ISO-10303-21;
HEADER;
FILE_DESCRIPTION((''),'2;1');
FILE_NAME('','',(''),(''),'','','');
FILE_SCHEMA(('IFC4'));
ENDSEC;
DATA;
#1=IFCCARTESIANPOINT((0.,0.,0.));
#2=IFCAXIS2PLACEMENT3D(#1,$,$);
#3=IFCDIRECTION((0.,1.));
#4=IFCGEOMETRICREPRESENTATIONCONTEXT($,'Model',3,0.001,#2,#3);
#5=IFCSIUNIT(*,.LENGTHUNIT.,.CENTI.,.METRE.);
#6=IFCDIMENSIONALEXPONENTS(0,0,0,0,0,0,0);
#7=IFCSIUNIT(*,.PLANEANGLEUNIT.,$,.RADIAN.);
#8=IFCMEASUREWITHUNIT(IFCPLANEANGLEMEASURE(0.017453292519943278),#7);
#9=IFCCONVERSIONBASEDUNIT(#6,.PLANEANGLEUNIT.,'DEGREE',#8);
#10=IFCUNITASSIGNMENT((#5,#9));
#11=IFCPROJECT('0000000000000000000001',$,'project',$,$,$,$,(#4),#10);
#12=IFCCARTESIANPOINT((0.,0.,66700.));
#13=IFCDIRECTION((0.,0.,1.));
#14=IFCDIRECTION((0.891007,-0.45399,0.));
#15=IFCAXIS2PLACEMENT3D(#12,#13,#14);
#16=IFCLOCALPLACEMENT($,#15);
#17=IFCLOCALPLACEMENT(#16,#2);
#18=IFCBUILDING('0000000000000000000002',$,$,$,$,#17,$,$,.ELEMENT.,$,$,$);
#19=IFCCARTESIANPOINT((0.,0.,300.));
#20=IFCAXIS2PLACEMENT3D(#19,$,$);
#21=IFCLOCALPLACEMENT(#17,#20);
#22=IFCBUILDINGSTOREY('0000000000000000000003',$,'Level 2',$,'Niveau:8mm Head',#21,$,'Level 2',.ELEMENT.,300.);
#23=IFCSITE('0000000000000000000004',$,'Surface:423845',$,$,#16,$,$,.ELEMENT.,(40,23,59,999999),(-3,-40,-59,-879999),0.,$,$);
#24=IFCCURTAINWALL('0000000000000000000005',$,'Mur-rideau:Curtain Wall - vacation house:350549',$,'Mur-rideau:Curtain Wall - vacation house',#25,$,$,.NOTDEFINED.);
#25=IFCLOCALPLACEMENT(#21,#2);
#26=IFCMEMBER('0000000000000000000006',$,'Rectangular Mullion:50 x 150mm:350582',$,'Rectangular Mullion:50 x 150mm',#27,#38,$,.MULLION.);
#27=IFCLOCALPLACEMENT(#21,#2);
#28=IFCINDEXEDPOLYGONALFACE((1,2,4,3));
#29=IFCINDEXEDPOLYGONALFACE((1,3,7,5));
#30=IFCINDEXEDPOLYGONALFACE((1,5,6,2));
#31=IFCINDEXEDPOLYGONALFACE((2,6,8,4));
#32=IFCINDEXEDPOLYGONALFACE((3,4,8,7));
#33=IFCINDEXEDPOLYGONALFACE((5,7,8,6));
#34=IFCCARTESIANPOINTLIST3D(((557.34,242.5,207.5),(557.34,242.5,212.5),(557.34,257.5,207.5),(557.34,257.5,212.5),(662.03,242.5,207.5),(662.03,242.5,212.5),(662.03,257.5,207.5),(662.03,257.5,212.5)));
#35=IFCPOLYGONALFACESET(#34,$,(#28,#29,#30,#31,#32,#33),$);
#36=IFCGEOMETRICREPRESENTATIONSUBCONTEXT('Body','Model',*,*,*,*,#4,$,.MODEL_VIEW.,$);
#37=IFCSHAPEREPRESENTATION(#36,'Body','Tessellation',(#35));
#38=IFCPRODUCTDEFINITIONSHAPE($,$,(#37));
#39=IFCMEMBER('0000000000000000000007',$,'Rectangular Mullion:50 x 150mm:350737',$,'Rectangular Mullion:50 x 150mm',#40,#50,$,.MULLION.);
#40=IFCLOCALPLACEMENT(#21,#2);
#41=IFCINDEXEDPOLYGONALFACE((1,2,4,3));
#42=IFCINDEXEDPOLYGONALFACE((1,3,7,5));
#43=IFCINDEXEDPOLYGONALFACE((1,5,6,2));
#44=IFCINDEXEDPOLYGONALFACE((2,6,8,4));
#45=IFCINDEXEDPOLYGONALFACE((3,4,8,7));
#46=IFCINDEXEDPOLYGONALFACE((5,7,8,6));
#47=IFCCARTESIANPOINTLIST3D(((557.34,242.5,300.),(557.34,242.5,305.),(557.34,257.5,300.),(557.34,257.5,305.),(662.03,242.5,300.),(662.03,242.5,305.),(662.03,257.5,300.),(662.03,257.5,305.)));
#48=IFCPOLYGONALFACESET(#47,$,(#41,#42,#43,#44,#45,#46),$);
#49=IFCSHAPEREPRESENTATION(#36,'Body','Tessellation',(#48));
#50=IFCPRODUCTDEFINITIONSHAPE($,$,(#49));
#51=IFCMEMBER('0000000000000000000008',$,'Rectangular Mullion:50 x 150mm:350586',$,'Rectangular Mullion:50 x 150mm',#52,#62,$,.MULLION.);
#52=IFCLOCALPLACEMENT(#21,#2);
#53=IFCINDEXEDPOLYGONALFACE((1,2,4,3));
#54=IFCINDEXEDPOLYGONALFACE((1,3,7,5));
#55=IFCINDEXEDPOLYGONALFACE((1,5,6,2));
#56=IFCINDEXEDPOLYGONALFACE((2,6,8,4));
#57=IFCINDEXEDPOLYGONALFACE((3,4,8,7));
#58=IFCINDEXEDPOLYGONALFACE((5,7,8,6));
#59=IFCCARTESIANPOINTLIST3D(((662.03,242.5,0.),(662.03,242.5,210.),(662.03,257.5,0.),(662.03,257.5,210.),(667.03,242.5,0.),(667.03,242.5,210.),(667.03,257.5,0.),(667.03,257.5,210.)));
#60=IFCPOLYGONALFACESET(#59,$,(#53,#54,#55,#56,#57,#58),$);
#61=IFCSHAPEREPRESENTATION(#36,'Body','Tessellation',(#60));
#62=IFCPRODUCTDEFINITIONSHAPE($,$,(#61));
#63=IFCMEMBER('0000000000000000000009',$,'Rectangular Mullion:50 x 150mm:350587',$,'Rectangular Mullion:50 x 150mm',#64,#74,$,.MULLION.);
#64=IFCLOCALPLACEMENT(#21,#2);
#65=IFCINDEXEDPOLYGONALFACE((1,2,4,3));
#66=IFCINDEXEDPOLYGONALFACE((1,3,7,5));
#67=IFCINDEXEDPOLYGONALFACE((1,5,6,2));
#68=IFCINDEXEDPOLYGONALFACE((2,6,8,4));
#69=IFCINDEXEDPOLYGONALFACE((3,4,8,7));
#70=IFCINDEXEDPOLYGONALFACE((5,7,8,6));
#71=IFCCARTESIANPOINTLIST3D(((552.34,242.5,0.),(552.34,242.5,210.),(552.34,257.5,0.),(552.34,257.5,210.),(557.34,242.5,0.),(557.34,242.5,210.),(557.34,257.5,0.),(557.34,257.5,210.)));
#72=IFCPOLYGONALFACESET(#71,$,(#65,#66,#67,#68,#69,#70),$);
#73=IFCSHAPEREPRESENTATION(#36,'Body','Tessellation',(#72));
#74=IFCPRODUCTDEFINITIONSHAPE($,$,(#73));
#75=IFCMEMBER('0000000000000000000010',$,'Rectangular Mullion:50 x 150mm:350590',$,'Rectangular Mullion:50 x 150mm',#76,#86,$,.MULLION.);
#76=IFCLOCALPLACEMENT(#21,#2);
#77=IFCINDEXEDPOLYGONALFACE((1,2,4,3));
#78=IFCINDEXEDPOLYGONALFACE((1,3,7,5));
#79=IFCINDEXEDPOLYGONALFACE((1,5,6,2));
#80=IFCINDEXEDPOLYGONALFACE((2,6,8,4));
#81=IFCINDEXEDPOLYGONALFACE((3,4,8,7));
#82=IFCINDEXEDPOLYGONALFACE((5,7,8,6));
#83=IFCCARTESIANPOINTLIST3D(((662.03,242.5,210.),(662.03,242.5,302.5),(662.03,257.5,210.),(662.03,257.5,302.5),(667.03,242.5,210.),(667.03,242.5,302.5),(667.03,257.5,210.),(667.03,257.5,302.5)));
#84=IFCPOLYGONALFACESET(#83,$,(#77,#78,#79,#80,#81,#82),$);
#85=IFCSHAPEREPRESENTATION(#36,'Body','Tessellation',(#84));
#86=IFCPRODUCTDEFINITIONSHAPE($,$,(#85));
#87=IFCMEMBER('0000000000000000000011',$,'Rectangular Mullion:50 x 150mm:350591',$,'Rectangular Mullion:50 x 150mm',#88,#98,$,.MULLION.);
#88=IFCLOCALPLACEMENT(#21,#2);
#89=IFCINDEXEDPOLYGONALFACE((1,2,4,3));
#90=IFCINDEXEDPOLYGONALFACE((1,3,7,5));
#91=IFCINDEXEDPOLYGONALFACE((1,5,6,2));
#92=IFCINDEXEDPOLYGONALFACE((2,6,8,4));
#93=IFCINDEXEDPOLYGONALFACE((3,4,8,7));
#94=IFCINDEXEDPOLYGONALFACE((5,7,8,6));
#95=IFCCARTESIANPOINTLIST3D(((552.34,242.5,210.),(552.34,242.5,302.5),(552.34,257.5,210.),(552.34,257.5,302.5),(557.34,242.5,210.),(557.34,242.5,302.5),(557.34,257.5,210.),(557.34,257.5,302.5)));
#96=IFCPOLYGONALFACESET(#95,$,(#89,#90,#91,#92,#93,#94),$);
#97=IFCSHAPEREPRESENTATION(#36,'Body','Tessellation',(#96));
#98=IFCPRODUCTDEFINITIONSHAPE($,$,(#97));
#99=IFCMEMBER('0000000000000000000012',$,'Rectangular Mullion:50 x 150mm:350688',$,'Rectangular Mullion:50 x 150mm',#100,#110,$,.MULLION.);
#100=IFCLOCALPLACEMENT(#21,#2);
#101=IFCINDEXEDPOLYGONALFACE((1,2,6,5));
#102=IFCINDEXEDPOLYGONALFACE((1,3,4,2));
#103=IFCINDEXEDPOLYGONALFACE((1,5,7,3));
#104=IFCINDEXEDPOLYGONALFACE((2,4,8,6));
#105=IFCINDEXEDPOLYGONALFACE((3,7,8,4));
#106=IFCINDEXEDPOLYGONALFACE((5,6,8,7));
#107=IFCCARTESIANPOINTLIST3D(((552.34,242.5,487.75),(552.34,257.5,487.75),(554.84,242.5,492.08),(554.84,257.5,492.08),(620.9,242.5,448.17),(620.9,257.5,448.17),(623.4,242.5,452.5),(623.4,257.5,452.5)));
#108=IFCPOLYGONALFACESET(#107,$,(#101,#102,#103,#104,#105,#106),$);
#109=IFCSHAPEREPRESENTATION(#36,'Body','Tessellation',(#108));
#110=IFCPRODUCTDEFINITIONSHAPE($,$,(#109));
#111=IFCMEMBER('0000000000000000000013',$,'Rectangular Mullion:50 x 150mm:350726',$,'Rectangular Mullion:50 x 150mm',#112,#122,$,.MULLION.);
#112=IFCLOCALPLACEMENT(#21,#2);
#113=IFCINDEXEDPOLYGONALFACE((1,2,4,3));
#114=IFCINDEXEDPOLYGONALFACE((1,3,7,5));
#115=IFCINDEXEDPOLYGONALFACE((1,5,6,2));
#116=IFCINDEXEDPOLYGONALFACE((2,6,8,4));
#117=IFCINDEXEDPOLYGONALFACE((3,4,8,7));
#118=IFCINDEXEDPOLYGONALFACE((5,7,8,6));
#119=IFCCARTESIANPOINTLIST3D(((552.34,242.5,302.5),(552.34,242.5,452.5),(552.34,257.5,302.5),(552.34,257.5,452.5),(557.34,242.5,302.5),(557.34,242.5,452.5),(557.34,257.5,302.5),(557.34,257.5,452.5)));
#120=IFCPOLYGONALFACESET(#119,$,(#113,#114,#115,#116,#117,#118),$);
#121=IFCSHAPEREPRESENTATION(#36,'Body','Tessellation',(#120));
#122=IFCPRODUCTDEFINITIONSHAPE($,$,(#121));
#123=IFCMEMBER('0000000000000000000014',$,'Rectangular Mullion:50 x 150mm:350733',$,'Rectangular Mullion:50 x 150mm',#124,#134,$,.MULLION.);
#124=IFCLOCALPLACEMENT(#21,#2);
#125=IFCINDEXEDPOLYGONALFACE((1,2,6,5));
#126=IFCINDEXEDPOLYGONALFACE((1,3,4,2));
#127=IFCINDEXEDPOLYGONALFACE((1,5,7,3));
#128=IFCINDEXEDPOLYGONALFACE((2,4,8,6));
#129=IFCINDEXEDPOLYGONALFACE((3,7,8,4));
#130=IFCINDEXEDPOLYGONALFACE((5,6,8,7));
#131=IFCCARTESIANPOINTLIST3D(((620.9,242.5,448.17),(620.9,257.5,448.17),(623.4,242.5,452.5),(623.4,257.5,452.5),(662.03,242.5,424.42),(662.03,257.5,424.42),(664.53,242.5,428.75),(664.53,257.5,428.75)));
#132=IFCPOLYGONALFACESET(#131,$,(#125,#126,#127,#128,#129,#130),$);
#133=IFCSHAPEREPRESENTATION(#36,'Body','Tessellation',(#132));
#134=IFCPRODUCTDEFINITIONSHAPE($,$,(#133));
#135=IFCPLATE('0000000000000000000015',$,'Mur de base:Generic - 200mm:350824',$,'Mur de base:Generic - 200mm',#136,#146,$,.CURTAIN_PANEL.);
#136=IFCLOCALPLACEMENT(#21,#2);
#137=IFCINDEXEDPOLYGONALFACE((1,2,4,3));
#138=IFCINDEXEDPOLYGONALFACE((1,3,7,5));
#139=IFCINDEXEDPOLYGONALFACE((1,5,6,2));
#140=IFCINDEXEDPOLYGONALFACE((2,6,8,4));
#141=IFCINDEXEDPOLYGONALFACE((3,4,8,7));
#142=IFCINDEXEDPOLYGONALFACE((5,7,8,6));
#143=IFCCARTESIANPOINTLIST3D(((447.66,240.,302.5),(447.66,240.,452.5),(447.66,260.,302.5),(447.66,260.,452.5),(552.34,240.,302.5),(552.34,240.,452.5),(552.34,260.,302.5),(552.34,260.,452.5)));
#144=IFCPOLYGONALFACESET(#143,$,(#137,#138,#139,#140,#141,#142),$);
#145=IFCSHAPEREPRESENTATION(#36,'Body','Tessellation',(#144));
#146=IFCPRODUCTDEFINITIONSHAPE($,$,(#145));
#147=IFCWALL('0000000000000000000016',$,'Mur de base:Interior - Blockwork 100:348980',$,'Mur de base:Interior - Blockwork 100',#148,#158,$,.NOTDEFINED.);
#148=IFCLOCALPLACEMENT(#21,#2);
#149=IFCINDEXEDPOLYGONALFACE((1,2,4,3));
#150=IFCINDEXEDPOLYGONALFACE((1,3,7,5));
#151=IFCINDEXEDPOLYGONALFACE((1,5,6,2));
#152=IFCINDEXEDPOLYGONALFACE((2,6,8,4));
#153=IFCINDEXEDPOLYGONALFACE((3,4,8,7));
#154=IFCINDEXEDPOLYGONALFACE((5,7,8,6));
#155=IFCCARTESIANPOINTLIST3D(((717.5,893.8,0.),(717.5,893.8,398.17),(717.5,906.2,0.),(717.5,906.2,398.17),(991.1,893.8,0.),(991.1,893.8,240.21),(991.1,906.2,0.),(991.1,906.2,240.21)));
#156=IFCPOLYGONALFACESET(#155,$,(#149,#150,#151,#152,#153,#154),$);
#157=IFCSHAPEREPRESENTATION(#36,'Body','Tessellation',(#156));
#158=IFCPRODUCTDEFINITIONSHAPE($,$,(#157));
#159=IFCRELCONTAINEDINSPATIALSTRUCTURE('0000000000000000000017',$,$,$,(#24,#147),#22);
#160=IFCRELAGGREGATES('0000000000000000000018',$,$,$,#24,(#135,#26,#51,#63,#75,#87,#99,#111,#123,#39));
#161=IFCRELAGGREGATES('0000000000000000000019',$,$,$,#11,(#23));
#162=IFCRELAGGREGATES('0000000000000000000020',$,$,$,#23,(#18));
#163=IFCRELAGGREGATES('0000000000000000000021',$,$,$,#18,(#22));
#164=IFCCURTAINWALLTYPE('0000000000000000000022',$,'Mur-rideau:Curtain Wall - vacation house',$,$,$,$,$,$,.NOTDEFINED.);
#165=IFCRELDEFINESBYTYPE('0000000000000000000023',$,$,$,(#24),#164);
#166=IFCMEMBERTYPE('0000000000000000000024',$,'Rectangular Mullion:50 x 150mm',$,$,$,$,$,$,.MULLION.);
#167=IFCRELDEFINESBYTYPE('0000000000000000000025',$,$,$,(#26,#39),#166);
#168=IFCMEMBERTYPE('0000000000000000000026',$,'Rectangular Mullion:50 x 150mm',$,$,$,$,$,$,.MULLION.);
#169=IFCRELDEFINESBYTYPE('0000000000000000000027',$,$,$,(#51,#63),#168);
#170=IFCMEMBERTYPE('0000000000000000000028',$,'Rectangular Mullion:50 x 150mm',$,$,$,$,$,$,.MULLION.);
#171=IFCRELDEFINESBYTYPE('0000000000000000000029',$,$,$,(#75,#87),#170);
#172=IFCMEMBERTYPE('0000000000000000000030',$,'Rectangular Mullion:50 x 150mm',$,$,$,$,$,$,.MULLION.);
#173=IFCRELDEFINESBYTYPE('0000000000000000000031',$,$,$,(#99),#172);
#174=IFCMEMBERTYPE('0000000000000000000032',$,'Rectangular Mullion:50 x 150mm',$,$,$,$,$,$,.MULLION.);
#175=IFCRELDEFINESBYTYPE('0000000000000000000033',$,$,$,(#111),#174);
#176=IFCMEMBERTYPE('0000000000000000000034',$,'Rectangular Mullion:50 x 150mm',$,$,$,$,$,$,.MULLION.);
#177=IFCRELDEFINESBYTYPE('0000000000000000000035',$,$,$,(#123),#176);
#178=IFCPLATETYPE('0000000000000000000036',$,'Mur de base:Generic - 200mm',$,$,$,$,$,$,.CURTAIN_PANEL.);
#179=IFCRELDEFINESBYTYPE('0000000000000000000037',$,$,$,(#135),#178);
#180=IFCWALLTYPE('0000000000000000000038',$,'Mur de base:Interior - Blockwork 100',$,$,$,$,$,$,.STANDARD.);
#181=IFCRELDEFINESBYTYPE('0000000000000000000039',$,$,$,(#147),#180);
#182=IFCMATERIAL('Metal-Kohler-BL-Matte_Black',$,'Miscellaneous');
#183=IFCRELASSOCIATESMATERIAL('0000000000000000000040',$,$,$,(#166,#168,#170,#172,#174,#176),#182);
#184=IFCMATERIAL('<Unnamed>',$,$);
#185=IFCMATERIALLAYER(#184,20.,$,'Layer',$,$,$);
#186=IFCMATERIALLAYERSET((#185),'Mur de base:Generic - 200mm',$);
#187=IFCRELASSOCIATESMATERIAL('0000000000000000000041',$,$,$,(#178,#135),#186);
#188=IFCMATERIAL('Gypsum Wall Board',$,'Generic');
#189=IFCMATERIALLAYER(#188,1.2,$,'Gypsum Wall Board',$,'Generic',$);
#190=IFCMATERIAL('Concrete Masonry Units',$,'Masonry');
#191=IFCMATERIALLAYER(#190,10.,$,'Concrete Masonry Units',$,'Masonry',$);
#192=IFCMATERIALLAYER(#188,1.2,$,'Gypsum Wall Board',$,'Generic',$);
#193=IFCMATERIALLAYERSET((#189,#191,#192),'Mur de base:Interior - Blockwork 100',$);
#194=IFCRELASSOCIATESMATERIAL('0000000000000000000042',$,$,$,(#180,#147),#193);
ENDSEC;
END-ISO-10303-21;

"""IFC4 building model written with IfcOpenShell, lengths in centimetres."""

from ifc_helpers import new_model, entity, si_unit, converted_unit, direction, frame, frame_2d, origin, origin_2d_with_axis, place, context, subcontext, project, spatial, polyline, rectangle, extrude, clip, bounded_halfspace, source, transform, mapped, material, layer, layer_set, layer_usage, material_profile, profile_set, type_object, type_shapes, element, aggregate, save


model = new_model("IFC4")

# Units and contexts
model_context = context("Model", 3, precision=0.001, world=origin(), true_north=direction((0.0, 1.0)))
body_context = subcontext(model_context, "Body", "Model", "MODEL_VIEW")
ifc_project = project(units=[si_unit("LENGTHUNIT", "METRE", prefix="CENTI"), converted_unit("PLANEANGLEUNIT", "DEGREE", entity("IfcPlaneAngleMeasure", 0.017453292519943278), si_unit("PLANEANGLEUNIT", "RADIAN"), dimensions=[0, 0, 0, 0, 0, 0, 0])], contexts=[model_context])

# Site, building, storey
site_placement = place(None, frame((0.0, 0.0, 66700.0), z_axis=(0.0, 0.0, 1.0), x_axis=(0.891007, -0.45399, 0.0)))
site = spatial("IfcSite", under=ifc_project, at=site_placement, Name="Surface:423845", CompositionType="ELEMENT", RefLatitude=(40, 23, 59, 999999), RefLongitude=(-3, -40, -59, -879999), RefElevation=0.0)
building_placement = place(site_placement, origin())
building = spatial("IfcBuilding", under=site, at=building_placement, CompositionType="ELEMENT")
storey_placement = place(building_placement, frame((0.0, 0.0, 300.0)))
storey = spatial("IfcBuildingStorey", under=building, at=storey_placement, Name="Level 2", ObjectType="Niveau:8mm Head", LongName="Level 2", CompositionType="ELEMENT", Elevation=300.0)

# Curtain wall, members, plate
curtain_wall_type = type_object("IfcCurtainWallType", Name="Mur-rideau:Curtain Wall - vacation house", PredefinedType="NOTDEFINED")
curtain_wall_placement = place(storey_placement, frame((0.0, 0.0, -300.0)))
curtain_wall = element("IfcCurtainWall", 1, at=curtain_wall_placement, inside=storey, type_object=curtain_wall_type, Name="Mur-rideau:Curtain Wall - vacation house:350549", ObjectType="Mur-rideau:Curtain Wall - vacation house", PredefinedType="NOTDEFINED")
ifc_material_1 = material(Name="Metal-Kohler-BL-Matte_Black", Category="Miscellaneous")
ifc_material_profile = material_profile(ifc_material_1, rectangle(XDim=5.0, YDim=15.0, at=origin_2d_with_axis()), Name="50 x 150mm")
ifc_profile_set = profile_set([ifc_material_profile], Name="50 x 150mm")
member_type_1 = type_object("IfcMemberType", Name="Rectangular Mullion:50 x 150mm", PredefinedType="MULLION", material=ifc_profile_set)
shared_shape_1 = source(origin(), body_context, "Body", "SweptSolid", [
    extrude(rectangle(XDim=5.0, YDim=15.0, at=origin_2d_with_axis()), frame((0.0, 0.0, -104.69), z_axis=(0.0, 0.0, 1.0), x_axis=(-1.0, 0.0, 0.0)), (0.0, 0.0, 1.0), 104.69),
])
type_shapes(member_type_1, [shared_shape_1])
member_1_placement = place(curtain_wall_placement, frame((557.34, 250.0, 510.0), z_axis=(-1.0, 0.0, 0.0), x_axis=(0.0, 0.0, 1.0)))
member_1 = element("IfcMember", 2, at=member_1_placement, type_object=member_type_1, Name="Rectangular Mullion:50 x 150mm:350582", ObjectType="Rectangular Mullion:50 x 150mm", PredefinedType="MULLION", context=body_context, shape_type="MappedRepresentation", body=[
    mapped(shared_shape_1, transform((0.0, 0.0, 0.0), scale=1.0)),
])
member_2_placement = place(curtain_wall_placement, frame((557.34, 250.0, 602.5), z_axis=(-1.0, 0.0, 0.0), x_axis=(0.0, 0.0, 1.0)))
member_2 = element("IfcMember", 3, at=member_2_placement, type_object=member_type_1, Name="Rectangular Mullion:50 x 150mm:350737", ObjectType="Rectangular Mullion:50 x 150mm", PredefinedType="MULLION", context=body_context, shape_type="MappedRepresentation", body=[
    mapped(shared_shape_1, transform((0.0, 0.0, 0.0), scale=1.0)),
])
member_type_2 = type_object("IfcMemberType", Name="Rectangular Mullion:50 x 150mm", PredefinedType="MULLION", material=ifc_profile_set)
shared_shape_2 = source(origin(), body_context, "Body", "SweptSolid", [
    extrude(rectangle(XDim=5.0, YDim=15.0, at=origin_2d_with_axis()), frame((0.0, 0.0, -210.0), z_axis=(0.0, 0.0, 1.0), x_axis=(-1.0, 0.0, 0.0)), (0.0, 0.0, 1.0), 210.0),
])
type_shapes(member_type_2, [shared_shape_2])
member_3_placement = place(curtain_wall_placement, frame((664.53, 250.0, 300.0), z_axis=(0.0, 0.0, -1.0), x_axis=(-1.0, 0.0, 0.0)))
member_3 = element("IfcMember", 4, at=member_3_placement, type_object=member_type_2, Name="Rectangular Mullion:50 x 150mm:350586", ObjectType="Rectangular Mullion:50 x 150mm", PredefinedType="MULLION", context=body_context, shape_type="MappedRepresentation", body=[
    mapped(shared_shape_2, transform((0.0, 0.0, 0.0), scale=1.0)),
])
member_4_placement = place(curtain_wall_placement, frame((554.84, 250.0, 300.0), z_axis=(0.0, 0.0, -1.0), x_axis=(-1.0, 0.0, 0.0)))
member_4 = element("IfcMember", 5, at=member_4_placement, type_object=member_type_2, Name="Rectangular Mullion:50 x 150mm:350587", ObjectType="Rectangular Mullion:50 x 150mm", PredefinedType="MULLION", context=body_context, shape_type="MappedRepresentation", body=[
    mapped(shared_shape_2, transform((0.0, 0.0, 0.0), scale=1.0)),
])
member_type_3 = type_object("IfcMemberType", Name="Rectangular Mullion:50 x 150mm", PredefinedType="MULLION", material=ifc_profile_set)
shared_shape_3 = source(origin(), body_context, "Body", "SweptSolid", [
    extrude(rectangle(XDim=5.0, YDim=15.0, at=origin_2d_with_axis()), frame((0.0, 0.0, -92.5), z_axis=(0.0, 0.0, 1.0), x_axis=(-1.0, 0.0, 0.0)), (0.0, 0.0, 1.0), 92.5),
])
type_shapes(member_type_3, [shared_shape_3])
member_5_placement = place(curtain_wall_placement, frame((664.53, 250.0, 510.0), z_axis=(0.0, 0.0, -1.0), x_axis=(-1.0, 0.0, 0.0)))
member_5 = element("IfcMember", 6, at=member_5_placement, type_object=member_type_3, Name="Rectangular Mullion:50 x 150mm:350590", ObjectType="Rectangular Mullion:50 x 150mm", PredefinedType="MULLION", context=body_context, shape_type="MappedRepresentation", body=[
    mapped(shared_shape_3, transform((0.0, 0.0, 0.0), scale=1.0)),
])
member_6_placement = place(curtain_wall_placement, frame((554.84, 250.0, 510.0), z_axis=(0.0, 0.0, -1.0), x_axis=(-1.0, 0.0, 0.0)))
member_6 = element("IfcMember", 7, at=member_6_placement, type_object=member_type_3, Name="Rectangular Mullion:50 x 150mm:350591", ObjectType="Rectangular Mullion:50 x 150mm", PredefinedType="MULLION", context=body_context, shape_type="MappedRepresentation", body=[
    mapped(shared_shape_3, transform((0.0, 0.0, 0.0), scale=1.0)),
])
member_type_4 = type_object("IfcMemberType", Name="Rectangular Mullion:50 x 150mm", PredefinedType="MULLION", material=ifc_profile_set)
shared_shape_4 = source(origin(), body_context, "Body", "SweptSolid", [
    extrude(rectangle(XDim=5.0, YDim=15.0, at=origin_2d_with_axis()), frame((-2.5, 0.0, -79.16), z_axis=(0.0, 0.0, 1.0), x_axis=(-1.0, 0.0, 0.0)), (0.0, 0.0, 1.0), 79.16),
])
type_shapes(member_type_4, [shared_shape_4])
member_7_placement = place(curtain_wall_placement, frame((554.84, 250.0, 792.08), z_axis=(-0.866025, 0.0, 0.5), x_axis=(0.5, 0.0, 0.866025)))
member_7 = element("IfcMember", 8, at=member_7_placement, type_object=member_type_4, Name="Rectangular Mullion:50 x 150mm:350688", ObjectType="Rectangular Mullion:50 x 150mm", PredefinedType="MULLION", context=body_context, shape_type="MappedRepresentation", body=[
    mapped(shared_shape_4, transform((0.0, 0.0, 0.0), scale=1.0)),
])
member_type_5 = type_object("IfcMemberType", Name="Rectangular Mullion:50 x 150mm", PredefinedType="MULLION", material=ifc_profile_set)
shared_shape_5 = source(origin(), body_context, "Body", "SweptSolid", [
    extrude(rectangle(XDim=5.0, YDim=15.0, at=origin_2d_with_axis()), frame((0.0, 0.0, -150.0), z_axis=(0.0, 0.0, 1.0), x_axis=(-1.0, 0.0, 0.0)), (0.0, 0.0, 1.0), 150.0),
])
type_shapes(member_type_5, [shared_shape_5])
member_8_placement = place(curtain_wall_placement, frame((554.84, 250.0, 602.5), z_axis=(0.0, 0.0, -1.0), x_axis=(-1.0, 0.0, 0.0)))
member_8 = element("IfcMember", 9, at=member_8_placement, type_object=member_type_5, Name="Rectangular Mullion:50 x 150mm:350726", ObjectType="Rectangular Mullion:50 x 150mm", PredefinedType="MULLION", context=body_context, shape_type="MappedRepresentation", body=[
    mapped(shared_shape_5, transform((0.0, 0.0, 0.0), scale=1.0)),
])
member_type_6 = type_object("IfcMemberType", Name="Rectangular Mullion:50 x 150mm", PredefinedType="MULLION", material=ifc_profile_set)
shared_shape_6 = source(origin(), body_context, "Body", "SweptSolid", [
    extrude(rectangle(XDim=5.0, YDim=15.0, at=origin_2d_with_axis()), frame((-2.5, 0.0, -47.5), z_axis=(0.0, 0.0, 1.0), x_axis=(-1.0, 0.0, 0.0)), (0.0, 0.0, 1.0), 47.5),
])
type_shapes(member_type_6, [shared_shape_6])
member_9_placement = place(curtain_wall_placement, frame((623.4, 250.0, 752.5), z_axis=(-0.866025, 0.0, 0.5), x_axis=(0.5, 0.0, 0.866025)))
member_9 = element("IfcMember", 10, at=member_9_placement, type_object=member_type_6, Name="Rectangular Mullion:50 x 150mm:350733", ObjectType="Rectangular Mullion:50 x 150mm", PredefinedType="MULLION", context=body_context, shape_type="MappedRepresentation", body=[
    mapped(shared_shape_6, transform((0.0, 0.0, 0.0), scale=1.0)),
])
ifc_material_2 = material(Name="<Unnamed>")
ifc_layer_1 = layer(ifc_material_2, 20.0, Name="Layer")
ifc_layer_set_1 = layer_set([ifc_layer_1], Name="Mur de base:Generic - 200mm")
ifc_layer_usage_1 = layer_usage(ifc_layer_set_1, "AXIS2", "NEGATIVE", 10.0)
plate_type_1 = type_object("IfcPlateType", Name="Mur de base:Generic - 200mm", PredefinedType="CURTAIN_PANEL", material=ifc_layer_set_1)
plate_1_placement = place(storey_placement, frame((552.34, 250.0, 302.5), z_axis=(0.0, 0.0, 1.0), x_axis=(-1.0, 0.0, 0.0)))
plate_1 = element("IfcPlate", 11, at=plate_1_placement, type_object=plate_type_1, material=ifc_layer_usage_1, Name="Mur de base:Generic - 200mm:350824", ObjectType="Mur de base:Generic - 200mm", PredefinedType="CURTAIN_PANEL", context=body_context, shape_type="SweptSolid", body=[
    extrude(rectangle(XDim=20.0, YDim=104.69, at=origin_2d_with_axis()), frame((52.34, 0.0, 0.0), z_axis=(0.0, 0.0, 1.0), x_axis=(0.0, 1.0, 0.0)), (0.0, 0.0, 1.0), 150.0),
])

# Wall
ifc_material_3 = material(Name="Gypsum Wall Board", Category="Generic")
ifc_layer_2 = layer(ifc_material_3, 1.2, Name="Gypsum Wall Board", Category="Generic")
ifc_material_4 = material(Name="Concrete Masonry Units", Category="Masonry")
ifc_layer_3 = layer(ifc_material_4, 10.0, Name="Concrete Masonry Units", Category="Masonry")
ifc_layer_4 = layer(ifc_material_3, 1.2, Name="Gypsum Wall Board", Category="Generic")
ifc_layer_set_2 = layer_set([ifc_layer_2, ifc_layer_3, ifc_layer_4], Name="Mur de base:Interior - Blockwork 100")
ifc_layer_usage_2 = layer_usage(ifc_layer_set_2, "AXIS2", "NEGATIVE", 6.2)
wall_type = type_object("IfcWallType", Name="Mur de base:Interior - Blockwork 100", PredefinedType="STANDARD", material=ifc_layer_set_2)
wall_1_placement = place(storey_placement, frame((991.1, 900.0, 0.0), z_axis=(0.0, 0.0, 1.0), x_axis=(-1.0, 0.0, 0.0)))
element("IfcWall", 12, at=wall_1_placement, inside=storey, type_object=wall_type, material=ifc_layer_usage_2, Name="Mur de base:Interior - Blockwork 100:348980", ObjectType="Mur de base:Interior - Blockwork 100", PredefinedType="NOTDEFINED", context=body_context, shape_type="Clipping", body=[
    clip(extrude(rectangle(XDim=273.6, YDim=12.4, at=frame_2d((136.8, 0.0), x_axis=(-1.0, 0.0))), origin(), (0.0, 0.0, 1.0), 398.17), bounded_halfspace(frame((0.0, -6.2, 240.21), z_axis=(-0.5, 0.0, 0.866025), x_axis=(0.0, -1.0, 0.0)), False, frame((0.0, -6.2, 240.21)), polyline([(0.0, 0.0), (273.6, 0.0), (273.6, 12.4), (0.0, 12.4), (0.0, 0.0)]))),
])

aggregate(curtain_wall, [plate_1, member_1, member_3, member_4, member_5, member_6, member_7, member_8, member_9, member_2])

save(model, "model.ifc")
